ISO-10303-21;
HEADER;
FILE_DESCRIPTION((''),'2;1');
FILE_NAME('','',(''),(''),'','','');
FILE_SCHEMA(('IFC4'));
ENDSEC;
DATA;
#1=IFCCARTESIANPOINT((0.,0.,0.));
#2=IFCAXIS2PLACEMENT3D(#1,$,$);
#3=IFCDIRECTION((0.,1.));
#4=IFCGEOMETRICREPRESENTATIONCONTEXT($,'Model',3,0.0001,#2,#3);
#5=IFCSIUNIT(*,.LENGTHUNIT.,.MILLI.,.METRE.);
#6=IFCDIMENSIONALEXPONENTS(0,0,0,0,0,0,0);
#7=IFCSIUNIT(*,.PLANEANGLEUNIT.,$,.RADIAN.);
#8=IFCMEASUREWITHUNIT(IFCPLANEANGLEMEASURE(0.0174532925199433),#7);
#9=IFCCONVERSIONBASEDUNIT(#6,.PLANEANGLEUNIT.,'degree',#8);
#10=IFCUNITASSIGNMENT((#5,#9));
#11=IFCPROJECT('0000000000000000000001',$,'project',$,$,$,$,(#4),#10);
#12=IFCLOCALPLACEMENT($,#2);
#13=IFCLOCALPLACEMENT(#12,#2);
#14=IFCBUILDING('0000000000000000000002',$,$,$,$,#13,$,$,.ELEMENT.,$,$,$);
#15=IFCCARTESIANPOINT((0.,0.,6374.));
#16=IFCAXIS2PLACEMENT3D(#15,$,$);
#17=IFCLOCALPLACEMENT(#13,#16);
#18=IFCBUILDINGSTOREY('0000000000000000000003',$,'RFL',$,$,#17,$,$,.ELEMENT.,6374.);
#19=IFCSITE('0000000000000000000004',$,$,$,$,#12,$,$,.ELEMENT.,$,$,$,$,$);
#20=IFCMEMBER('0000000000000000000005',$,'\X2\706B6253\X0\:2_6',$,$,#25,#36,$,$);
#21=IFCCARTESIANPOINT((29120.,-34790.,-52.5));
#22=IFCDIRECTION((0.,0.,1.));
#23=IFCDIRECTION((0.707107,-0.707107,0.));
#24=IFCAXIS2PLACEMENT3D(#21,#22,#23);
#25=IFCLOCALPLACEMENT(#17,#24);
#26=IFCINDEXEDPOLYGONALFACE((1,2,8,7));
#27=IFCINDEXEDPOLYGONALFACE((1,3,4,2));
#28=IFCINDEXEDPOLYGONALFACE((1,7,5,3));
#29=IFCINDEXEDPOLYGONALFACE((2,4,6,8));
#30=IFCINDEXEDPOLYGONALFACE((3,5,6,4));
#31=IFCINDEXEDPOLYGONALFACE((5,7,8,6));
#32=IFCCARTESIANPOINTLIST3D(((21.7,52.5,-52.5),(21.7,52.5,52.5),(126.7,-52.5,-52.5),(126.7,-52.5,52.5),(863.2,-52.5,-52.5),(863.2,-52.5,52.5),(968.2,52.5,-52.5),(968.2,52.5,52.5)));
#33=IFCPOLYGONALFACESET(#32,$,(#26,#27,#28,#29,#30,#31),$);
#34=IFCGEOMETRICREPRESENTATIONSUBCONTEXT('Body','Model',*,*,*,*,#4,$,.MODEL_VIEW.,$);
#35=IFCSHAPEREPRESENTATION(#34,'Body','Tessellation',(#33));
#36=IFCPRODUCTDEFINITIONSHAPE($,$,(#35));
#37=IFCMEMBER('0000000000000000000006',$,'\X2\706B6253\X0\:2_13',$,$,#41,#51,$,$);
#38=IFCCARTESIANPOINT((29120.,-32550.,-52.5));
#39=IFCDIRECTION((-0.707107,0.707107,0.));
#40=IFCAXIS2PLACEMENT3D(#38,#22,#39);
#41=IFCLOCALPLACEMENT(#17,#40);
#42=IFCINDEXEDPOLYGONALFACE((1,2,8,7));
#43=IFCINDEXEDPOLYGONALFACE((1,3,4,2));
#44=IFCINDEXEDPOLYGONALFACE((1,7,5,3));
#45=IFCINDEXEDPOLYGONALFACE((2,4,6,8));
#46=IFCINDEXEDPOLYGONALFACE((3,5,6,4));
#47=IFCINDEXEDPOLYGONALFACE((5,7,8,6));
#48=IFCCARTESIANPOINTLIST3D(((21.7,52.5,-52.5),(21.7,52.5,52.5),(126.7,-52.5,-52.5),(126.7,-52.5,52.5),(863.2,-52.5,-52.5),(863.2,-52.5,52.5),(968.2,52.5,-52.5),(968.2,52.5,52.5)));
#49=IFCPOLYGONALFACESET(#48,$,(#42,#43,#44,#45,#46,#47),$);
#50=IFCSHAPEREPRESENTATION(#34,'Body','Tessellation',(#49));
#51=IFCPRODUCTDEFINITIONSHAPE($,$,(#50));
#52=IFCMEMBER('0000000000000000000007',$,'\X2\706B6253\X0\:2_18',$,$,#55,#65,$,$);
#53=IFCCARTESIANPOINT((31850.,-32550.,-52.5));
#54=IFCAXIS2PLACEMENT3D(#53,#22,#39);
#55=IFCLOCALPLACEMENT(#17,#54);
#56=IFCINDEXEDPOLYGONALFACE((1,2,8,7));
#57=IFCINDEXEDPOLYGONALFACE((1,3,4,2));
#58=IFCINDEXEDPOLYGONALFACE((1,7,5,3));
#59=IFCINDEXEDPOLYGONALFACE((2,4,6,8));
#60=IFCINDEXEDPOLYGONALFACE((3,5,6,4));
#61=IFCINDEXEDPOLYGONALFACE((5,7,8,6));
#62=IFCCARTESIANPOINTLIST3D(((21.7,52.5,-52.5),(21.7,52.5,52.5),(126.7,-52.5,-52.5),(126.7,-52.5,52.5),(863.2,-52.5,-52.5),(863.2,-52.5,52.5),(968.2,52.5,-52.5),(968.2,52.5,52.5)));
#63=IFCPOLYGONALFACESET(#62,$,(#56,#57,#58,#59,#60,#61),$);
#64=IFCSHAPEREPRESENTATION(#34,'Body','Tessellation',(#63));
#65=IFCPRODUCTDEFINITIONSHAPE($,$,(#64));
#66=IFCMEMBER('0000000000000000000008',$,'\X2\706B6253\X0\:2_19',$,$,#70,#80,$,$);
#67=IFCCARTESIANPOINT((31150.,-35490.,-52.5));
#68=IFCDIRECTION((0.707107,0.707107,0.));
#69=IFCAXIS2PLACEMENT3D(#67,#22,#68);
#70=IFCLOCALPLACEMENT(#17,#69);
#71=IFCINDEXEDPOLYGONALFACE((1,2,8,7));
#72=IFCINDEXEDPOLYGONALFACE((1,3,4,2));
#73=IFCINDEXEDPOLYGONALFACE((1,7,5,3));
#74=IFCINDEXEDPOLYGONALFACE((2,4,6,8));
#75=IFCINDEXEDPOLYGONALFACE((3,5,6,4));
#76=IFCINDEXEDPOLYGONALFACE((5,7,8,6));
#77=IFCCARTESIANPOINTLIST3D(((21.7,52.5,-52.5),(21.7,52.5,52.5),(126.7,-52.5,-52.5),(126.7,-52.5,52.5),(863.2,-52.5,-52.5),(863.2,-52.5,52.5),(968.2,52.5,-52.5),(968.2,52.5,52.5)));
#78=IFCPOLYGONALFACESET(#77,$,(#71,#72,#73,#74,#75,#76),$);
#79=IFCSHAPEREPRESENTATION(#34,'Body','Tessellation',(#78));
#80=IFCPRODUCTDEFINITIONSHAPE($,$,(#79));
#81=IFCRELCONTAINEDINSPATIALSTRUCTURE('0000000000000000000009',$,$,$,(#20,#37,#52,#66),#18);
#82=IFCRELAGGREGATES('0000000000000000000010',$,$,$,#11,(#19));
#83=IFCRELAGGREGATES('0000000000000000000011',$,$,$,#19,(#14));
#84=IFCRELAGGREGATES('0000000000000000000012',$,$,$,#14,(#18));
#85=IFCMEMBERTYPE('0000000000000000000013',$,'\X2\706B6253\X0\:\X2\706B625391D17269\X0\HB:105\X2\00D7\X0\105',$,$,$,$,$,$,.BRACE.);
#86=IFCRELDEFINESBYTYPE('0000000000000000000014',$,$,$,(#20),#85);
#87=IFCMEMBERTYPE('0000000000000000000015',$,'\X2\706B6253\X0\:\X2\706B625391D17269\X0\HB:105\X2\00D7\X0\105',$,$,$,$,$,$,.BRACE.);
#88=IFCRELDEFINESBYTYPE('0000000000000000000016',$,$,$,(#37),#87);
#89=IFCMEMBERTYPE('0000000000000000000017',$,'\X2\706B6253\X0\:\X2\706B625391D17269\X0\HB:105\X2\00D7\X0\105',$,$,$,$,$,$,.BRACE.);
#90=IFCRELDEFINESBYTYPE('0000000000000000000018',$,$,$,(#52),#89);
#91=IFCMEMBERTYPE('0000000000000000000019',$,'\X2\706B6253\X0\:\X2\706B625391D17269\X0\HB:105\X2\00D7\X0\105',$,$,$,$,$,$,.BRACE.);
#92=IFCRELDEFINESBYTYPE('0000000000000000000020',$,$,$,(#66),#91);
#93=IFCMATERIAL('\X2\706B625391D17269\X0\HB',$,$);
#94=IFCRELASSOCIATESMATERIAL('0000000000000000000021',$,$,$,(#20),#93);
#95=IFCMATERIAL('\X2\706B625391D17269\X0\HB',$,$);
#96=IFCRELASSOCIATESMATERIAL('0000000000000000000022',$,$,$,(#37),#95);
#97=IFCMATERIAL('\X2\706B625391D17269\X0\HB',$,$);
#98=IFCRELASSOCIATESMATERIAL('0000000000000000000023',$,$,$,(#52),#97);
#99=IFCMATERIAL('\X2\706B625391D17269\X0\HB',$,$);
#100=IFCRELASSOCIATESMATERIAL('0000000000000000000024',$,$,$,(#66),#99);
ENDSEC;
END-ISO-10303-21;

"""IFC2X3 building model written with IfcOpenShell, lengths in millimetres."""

from ifc_helpers import new_model, entity, si_unit, converted_unit, direction, frame, origin, place, context, subcontext, project, spatial, polyline, outline, extrude, material, type_object, element, save


model = new_model("IFC2X3")

# Units and contexts
model_context = context("Model", 3, precision=0.0001, world=origin(), true_north=direction((0.0, 1.0)))
body_context = subcontext(model_context, "Body", "Model", "MODEL_VIEW")
ifc_project = project(units=[si_unit("LENGTHUNIT", "METRE", prefix="MILLI"), converted_unit("PLANEANGLEUNIT", "degree", entity("IfcPlaneAngleMeasure", 0.0174532925199433), si_unit("PLANEANGLEUNIT", "RADIAN"), dimensions=[0, 0, 0, 0, 0, 0, 0])], contexts=[model_context])

# Site, building, storey
site_placement = place(None, origin())
site = spatial("IfcSite", under=ifc_project, at=site_placement, CompositionType="ELEMENT")
building_placement = place(site_placement, origin())
building = spatial("IfcBuilding", under=site, at=building_placement, CompositionType="ELEMENT")
storey_placement = place(building_placement, frame((0.0, 0.0, 6374.0)))
storey = spatial("IfcBuildingStorey", under=building, at=storey_placement, Name="RFL", CompositionType="ELEMENT", Elevation=6374.0)

# Members
ifc_material_1 = material(Name="火打金物HB")
member_type_1 = type_object("IfcMemberType", Name="火打:火打金物HB:105×105", PredefinedType="BRACE")
member_1_placement = place(storey_placement, frame((29120.0, -34790.0, -52.5), z_axis=(0.0, 0.0, 1.0), x_axis=(0.707107, -0.707107, 0.0)))
element("IfcMember", 1, at=member_1_placement, inside=storey, type_object=member_type_1, material=ifc_material_1, Name="火打:2_6", context=body_context, shape_type="SweptSolid", body=[
    extrude(outline(polyline([(126.7, -52.5, 0.0), (21.7, 52.5, 0.0), (968.2, 52.5, 0.0), (863.2, -52.5, 0.0), (126.7, -52.5, 0.0)])), frame((0.0, 0.0, -52.5), z_axis=(0.0, 0.0, 1.0), x_axis=(1.0, 0.0, 0.0)), (0.0, 0.0, 1.0), 105.0),
])
ifc_material_2 = material(Name="火打金物HB")
member_type_2 = type_object("IfcMemberType", Name="火打:火打金物HB:105×105", PredefinedType="BRACE")
member_2_placement = place(storey_placement, frame((29120.0, -32550.0, -52.5), z_axis=(0.0, 0.0, 1.0), x_axis=(-0.707107, 0.707107, 0.0)))
element("IfcMember", 2, at=member_2_placement, inside=storey, type_object=member_type_2, material=ifc_material_2, Name="火打:2_13", context=body_context, shape_type="SweptSolid", body=[
    extrude(outline(polyline([(126.7, -52.5, 0.0), (21.7, 52.5, 0.0), (968.2, 52.5, 0.0), (863.2, -52.5, 0.0), (126.7, -52.5, 0.0)])), frame((0.0, 0.0, -52.5), z_axis=(0.0, 0.0, 1.0), x_axis=(1.0, 0.0, 0.0)), (0.0, 0.0, 1.0), 105.0),
])
ifc_material_3 = material(Name="火打金物HB")
member_type_3 = type_object("IfcMemberType", Name="火打:火打金物HB:105×105", PredefinedType="BRACE")
member_3_placement = place(storey_placement, frame((31850.0, -32550.0, -52.5), z_axis=(0.0, 0.0, 1.0), x_axis=(-0.707107, 0.707107, 0.0)))
element("IfcMember", 3, at=member_3_placement, inside=storey, type_object=member_type_3, material=ifc_material_3, Name="火打:2_18", context=body_context, shape_type="SweptSolid", body=[
    extrude(outline(polyline([(126.7, -52.5, 0.0), (21.7, 52.5, 0.0), (968.2, 52.5, 0.0), (863.2, -52.5, 0.0), (126.7, -52.5, 0.0)])), frame((0.0, 0.0, -52.5), z_axis=(0.0, 0.0, 1.0), x_axis=(1.0, 0.0, 0.0)), (0.0, 0.0, 1.0), 105.0),
])
ifc_material_4 = material(Name="火打金物HB")
member_type_4 = type_object("IfcMemberType", Name="火打:火打金物HB:105×105", PredefinedType="BRACE")
member_4_placement = place(storey_placement, frame((31150.0, -35490.0, -52.5), z_axis=(0.0, 0.0, 1.0), x_axis=(0.707107, 0.707107, 0.0)))
element("IfcMember", 4, at=member_4_placement, inside=storey, type_object=member_type_4, material=ifc_material_4, Name="火打:2_19", context=body_context, shape_type="SweptSolid", body=[
    extrude(outline(polyline([(126.7, -52.5, 0.0), (21.7, 52.5, 0.0), (968.2, 52.5, 0.0), (863.2, -52.5, 0.0), (126.7, -52.5, 0.0)])), frame((0.0, 0.0, -52.5), z_axis=(0.0, 0.0, 1.0), x_axis=(1.0, 0.0, 0.0)), (0.0, 0.0, 1.0), 105.0),
])

save(model, "model.ifc")
